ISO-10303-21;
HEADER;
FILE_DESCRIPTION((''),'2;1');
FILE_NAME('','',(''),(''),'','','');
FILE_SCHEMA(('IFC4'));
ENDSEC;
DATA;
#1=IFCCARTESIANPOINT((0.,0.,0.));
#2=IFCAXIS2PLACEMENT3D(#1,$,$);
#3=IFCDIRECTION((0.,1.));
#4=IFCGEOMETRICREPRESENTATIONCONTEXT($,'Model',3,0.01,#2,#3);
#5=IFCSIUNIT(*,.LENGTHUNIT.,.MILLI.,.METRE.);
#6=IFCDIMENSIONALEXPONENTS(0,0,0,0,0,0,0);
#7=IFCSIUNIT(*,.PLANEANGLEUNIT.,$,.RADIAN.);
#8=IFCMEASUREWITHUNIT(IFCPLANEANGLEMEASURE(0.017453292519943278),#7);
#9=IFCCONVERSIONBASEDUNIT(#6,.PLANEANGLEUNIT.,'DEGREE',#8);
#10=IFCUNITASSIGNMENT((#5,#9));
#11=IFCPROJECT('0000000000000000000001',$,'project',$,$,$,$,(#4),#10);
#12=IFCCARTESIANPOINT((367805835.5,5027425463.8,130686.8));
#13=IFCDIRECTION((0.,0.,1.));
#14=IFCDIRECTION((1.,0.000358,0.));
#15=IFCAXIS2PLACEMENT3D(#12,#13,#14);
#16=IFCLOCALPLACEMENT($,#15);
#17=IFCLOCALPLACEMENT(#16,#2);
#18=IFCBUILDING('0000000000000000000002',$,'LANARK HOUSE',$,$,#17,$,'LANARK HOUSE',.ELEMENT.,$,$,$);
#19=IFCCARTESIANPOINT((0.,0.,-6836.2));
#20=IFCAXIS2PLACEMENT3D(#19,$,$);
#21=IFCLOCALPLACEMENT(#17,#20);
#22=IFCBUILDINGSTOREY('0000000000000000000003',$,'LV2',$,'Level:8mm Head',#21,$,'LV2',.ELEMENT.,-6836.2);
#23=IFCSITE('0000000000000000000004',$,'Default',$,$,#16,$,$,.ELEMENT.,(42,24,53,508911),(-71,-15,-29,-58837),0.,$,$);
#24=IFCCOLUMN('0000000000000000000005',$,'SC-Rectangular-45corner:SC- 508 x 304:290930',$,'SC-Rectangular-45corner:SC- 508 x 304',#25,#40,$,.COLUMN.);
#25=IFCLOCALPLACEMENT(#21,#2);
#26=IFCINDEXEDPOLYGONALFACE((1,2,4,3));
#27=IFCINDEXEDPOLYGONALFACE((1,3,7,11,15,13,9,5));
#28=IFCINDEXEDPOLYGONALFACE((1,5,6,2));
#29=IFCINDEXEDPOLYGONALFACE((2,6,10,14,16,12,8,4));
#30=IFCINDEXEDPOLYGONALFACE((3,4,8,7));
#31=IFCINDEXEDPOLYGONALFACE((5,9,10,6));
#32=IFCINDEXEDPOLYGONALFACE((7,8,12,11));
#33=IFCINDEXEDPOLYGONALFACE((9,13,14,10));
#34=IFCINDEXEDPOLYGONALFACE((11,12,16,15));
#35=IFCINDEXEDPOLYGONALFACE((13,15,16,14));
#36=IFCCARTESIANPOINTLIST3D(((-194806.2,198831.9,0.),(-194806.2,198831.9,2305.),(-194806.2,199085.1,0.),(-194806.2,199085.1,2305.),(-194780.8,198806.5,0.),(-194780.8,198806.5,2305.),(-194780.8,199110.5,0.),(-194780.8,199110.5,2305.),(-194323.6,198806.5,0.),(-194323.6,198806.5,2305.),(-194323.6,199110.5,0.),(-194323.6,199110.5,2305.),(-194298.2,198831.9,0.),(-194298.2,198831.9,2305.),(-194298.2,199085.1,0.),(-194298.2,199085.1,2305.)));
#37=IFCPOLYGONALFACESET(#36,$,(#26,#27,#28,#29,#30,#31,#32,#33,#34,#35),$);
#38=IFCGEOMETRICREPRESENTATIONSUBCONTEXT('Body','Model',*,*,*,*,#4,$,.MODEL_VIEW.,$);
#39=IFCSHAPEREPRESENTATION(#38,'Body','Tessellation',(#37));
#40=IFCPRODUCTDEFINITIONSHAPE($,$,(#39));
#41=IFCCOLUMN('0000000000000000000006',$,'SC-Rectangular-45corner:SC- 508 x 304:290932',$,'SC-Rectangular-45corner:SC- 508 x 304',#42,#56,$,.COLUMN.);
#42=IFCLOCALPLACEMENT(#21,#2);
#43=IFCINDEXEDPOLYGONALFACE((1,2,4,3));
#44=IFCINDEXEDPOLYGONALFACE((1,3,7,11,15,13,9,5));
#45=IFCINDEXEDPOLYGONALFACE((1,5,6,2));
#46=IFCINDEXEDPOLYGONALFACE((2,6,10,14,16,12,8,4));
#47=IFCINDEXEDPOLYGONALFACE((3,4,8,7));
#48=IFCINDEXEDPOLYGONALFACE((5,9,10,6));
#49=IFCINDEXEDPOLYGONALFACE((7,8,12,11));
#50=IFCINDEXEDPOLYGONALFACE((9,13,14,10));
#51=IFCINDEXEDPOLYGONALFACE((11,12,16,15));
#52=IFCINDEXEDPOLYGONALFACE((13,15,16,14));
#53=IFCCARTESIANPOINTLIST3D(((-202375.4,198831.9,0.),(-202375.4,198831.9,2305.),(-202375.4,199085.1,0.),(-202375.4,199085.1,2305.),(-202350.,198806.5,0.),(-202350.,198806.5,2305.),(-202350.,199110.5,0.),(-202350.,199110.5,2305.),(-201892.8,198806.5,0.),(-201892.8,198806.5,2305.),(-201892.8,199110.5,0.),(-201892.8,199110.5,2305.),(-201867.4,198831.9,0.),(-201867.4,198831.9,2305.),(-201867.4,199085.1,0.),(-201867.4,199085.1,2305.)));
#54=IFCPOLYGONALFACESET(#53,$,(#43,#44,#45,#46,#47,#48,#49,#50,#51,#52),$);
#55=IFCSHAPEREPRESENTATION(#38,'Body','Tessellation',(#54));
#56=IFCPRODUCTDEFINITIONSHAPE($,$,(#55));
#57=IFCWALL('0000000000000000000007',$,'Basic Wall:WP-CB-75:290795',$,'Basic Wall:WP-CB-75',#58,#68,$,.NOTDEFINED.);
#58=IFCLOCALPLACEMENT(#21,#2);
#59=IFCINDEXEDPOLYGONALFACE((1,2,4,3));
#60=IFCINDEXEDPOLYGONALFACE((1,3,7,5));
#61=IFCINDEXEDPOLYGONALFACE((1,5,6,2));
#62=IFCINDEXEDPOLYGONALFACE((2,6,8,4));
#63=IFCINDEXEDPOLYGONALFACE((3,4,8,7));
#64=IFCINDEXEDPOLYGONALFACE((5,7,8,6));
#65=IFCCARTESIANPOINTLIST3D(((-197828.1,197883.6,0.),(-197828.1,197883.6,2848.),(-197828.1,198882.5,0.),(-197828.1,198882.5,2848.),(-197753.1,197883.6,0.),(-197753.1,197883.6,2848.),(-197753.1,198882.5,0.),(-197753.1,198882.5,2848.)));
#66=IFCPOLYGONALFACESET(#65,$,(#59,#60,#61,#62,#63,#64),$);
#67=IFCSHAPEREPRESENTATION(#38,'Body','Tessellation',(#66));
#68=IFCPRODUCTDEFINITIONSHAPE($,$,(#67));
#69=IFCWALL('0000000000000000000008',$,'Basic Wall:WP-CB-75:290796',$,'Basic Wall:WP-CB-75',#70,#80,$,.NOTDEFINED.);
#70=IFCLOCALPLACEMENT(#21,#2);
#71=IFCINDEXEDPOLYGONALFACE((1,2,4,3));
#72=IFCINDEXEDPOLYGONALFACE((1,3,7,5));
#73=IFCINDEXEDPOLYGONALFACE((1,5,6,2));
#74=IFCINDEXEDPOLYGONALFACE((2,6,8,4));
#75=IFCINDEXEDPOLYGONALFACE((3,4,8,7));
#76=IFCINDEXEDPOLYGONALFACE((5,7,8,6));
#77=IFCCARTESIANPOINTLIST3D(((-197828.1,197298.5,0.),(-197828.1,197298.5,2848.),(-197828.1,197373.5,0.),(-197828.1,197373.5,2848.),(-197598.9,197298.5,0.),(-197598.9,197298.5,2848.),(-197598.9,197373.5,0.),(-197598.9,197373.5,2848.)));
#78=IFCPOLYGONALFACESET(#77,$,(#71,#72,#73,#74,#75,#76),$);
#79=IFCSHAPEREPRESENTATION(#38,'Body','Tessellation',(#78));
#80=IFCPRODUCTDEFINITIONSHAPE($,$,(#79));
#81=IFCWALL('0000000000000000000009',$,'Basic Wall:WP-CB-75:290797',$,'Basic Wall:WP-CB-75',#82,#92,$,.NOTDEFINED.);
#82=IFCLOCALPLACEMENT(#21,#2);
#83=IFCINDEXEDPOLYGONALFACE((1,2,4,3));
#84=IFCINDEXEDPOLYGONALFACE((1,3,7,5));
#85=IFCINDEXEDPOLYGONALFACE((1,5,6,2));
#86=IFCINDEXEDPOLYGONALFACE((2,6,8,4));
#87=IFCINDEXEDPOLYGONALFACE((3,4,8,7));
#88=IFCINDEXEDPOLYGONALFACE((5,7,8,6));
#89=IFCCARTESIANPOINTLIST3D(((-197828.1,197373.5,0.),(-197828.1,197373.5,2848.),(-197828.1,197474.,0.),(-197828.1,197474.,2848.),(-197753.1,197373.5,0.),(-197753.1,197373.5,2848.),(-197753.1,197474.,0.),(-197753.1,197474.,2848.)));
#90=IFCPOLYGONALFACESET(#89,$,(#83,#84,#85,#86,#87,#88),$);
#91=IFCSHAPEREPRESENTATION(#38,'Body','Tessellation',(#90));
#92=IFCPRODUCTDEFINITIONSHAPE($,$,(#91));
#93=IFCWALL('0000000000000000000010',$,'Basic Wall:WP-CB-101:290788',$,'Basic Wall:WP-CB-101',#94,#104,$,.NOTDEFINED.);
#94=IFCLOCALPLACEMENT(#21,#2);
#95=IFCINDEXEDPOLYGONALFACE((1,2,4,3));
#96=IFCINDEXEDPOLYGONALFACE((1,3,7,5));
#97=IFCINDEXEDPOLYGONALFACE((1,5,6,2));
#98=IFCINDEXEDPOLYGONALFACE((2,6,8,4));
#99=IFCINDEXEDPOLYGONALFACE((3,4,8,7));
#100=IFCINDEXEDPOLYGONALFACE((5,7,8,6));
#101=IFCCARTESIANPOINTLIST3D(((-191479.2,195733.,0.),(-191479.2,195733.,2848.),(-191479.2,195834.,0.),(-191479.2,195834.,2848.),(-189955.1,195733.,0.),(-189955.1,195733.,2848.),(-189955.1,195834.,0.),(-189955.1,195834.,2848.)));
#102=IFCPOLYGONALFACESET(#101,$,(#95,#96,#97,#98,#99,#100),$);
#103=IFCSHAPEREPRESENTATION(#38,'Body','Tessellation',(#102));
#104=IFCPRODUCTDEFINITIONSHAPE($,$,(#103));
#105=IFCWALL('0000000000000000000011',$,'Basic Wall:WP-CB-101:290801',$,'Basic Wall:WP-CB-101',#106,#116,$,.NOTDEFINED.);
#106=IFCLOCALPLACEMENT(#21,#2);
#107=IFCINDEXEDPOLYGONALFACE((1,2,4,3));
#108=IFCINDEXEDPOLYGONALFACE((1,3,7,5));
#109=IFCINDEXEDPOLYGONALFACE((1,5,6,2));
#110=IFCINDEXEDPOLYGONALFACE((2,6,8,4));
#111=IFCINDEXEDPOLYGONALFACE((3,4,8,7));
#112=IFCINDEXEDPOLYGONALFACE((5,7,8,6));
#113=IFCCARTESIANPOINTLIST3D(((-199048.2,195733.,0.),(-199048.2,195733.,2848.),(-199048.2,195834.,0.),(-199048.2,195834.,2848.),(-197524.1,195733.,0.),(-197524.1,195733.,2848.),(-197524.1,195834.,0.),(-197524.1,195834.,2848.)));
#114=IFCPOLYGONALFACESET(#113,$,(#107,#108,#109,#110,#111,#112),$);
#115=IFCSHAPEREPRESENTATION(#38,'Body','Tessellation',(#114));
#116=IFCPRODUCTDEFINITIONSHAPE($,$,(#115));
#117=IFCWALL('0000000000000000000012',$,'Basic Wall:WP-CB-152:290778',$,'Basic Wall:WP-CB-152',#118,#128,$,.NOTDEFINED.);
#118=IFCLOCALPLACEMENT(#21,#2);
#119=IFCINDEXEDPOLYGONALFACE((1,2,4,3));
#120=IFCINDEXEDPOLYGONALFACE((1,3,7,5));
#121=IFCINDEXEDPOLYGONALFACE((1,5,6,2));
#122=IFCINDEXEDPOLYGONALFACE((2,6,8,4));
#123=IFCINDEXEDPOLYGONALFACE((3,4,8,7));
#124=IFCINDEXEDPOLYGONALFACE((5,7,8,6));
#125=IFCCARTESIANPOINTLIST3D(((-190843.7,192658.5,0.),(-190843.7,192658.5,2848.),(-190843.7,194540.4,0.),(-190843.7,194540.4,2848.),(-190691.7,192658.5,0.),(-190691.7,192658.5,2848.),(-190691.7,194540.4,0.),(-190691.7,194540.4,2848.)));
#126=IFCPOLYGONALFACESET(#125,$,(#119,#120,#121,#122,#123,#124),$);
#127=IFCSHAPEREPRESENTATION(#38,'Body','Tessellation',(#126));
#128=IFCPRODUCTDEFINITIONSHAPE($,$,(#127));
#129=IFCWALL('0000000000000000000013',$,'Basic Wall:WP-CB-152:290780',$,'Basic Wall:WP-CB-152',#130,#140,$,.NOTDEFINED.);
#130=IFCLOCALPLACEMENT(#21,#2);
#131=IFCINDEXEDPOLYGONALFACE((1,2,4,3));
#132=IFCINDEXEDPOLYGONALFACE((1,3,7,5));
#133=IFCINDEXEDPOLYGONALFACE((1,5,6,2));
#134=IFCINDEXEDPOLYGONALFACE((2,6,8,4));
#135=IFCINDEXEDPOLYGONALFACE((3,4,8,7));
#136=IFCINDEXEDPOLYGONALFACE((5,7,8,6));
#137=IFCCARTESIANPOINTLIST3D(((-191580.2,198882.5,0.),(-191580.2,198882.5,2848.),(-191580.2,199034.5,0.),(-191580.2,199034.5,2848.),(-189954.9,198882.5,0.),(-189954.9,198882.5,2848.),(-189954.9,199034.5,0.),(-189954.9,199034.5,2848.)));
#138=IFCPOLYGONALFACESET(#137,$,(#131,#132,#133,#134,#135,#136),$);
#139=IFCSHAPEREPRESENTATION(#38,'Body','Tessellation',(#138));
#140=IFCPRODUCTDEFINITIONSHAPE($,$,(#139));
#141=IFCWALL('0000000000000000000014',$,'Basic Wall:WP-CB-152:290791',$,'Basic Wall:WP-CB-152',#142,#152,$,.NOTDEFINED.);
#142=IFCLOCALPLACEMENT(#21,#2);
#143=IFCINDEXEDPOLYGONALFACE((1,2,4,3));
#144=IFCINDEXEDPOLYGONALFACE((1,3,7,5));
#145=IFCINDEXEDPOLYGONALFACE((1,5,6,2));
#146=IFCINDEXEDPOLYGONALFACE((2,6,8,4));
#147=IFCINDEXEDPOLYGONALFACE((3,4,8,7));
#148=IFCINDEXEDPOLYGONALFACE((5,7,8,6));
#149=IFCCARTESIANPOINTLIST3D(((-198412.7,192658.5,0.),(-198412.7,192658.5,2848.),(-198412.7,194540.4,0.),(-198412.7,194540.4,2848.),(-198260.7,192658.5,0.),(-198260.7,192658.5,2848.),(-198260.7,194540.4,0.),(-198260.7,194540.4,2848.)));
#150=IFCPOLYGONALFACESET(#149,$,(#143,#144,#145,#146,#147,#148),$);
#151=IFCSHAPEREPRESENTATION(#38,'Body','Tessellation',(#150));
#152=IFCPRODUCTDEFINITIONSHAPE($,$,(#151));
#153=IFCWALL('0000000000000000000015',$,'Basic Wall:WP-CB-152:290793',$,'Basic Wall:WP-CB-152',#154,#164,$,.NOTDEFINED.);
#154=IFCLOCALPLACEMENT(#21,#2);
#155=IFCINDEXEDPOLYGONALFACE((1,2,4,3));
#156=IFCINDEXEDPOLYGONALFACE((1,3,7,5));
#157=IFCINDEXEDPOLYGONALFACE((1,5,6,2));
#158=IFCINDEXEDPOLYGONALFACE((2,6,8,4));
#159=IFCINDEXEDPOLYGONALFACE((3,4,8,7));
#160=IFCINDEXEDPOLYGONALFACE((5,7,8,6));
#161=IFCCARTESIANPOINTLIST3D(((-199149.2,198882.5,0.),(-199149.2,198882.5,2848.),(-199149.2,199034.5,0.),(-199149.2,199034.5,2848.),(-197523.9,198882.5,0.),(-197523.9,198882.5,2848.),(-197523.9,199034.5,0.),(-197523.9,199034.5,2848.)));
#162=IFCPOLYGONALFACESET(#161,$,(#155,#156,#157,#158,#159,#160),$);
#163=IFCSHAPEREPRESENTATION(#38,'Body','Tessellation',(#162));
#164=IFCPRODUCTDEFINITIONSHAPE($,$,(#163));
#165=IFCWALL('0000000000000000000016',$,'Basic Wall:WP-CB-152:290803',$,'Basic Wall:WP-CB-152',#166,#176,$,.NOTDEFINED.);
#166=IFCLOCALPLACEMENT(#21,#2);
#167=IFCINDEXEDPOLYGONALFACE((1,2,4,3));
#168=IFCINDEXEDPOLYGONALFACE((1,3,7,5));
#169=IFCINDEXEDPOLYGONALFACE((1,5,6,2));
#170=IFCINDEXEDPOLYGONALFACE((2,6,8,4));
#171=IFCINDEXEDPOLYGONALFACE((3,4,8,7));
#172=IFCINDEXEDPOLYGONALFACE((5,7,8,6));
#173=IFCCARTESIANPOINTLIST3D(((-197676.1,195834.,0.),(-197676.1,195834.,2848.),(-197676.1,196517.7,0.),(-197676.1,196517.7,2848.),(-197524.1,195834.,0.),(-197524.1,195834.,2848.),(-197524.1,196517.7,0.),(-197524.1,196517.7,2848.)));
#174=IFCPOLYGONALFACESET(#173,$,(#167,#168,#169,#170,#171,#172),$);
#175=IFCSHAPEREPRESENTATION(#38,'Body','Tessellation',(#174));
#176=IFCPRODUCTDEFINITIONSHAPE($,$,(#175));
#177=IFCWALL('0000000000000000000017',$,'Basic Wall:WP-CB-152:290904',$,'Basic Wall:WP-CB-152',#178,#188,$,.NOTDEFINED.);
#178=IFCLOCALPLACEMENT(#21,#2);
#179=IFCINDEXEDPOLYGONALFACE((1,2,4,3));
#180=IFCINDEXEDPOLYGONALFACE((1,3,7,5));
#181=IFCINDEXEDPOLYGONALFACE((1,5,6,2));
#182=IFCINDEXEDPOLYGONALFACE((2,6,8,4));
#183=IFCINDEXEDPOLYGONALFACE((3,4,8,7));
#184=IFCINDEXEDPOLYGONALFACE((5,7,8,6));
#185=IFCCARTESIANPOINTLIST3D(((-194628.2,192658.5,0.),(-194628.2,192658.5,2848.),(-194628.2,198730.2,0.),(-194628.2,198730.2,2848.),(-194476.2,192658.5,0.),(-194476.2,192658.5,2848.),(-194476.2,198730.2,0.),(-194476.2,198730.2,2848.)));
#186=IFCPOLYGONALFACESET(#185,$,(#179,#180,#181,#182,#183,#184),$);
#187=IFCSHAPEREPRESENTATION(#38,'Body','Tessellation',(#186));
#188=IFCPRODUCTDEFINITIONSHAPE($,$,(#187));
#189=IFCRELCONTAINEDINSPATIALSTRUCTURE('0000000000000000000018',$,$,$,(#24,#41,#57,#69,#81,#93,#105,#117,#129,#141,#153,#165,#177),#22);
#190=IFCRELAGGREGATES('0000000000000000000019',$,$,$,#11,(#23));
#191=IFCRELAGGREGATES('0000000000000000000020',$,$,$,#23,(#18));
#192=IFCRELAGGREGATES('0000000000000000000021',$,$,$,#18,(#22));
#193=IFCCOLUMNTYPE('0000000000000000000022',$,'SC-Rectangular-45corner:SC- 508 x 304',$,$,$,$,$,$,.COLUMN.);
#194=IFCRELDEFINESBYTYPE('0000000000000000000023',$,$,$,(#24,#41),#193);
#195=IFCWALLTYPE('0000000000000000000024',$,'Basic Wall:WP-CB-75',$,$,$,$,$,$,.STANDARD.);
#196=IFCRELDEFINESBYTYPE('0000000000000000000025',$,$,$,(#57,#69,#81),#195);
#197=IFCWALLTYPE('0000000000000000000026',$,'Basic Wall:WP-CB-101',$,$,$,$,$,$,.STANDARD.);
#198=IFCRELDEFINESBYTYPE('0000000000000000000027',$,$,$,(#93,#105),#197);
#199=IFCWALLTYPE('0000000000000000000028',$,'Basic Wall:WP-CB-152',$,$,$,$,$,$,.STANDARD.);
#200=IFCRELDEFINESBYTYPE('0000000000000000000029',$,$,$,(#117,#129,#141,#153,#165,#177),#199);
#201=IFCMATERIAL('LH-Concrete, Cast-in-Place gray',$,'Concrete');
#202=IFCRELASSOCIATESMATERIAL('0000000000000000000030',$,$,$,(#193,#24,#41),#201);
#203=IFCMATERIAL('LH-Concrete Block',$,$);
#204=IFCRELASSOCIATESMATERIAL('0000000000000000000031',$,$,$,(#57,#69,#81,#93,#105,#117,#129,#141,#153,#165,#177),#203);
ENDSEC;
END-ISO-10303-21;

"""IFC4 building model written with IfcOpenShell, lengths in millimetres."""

from ifc_helpers import new_model, entity, si_unit, converted_unit, direction, frame, origin, place, context, subcontext, project, spatial, indexed_curve, outline, extrude, source, transform, mapped, material, type_object, type_shapes, element, save


model = new_model("IFC4")

# Units and contexts
model_context = context("Model", 3, precision=0.01, world=origin(), true_north=direction((0.0, 1.0)))
body_context = subcontext(model_context, "Body", "Model", "MODEL_VIEW")
ifc_project = project(units=[si_unit("LENGTHUNIT", "METRE", prefix="MILLI"), converted_unit("PLANEANGLEUNIT", "DEGREE", entity("IfcPlaneAngleMeasure", 0.017453292519943278), si_unit("PLANEANGLEUNIT", "RADIAN"), dimensions=[0, 0, 0, 0, 0, 0, 0])], contexts=[model_context])

# Site, building, storey
site_placement = place(None, frame((367805835.5, 5027425463.8, 130686.8), z_axis=(0.0, 0.0, 1.0), x_axis=(1.0, 0.000358, 0.0)))
site = spatial("IfcSite", under=ifc_project, at=site_placement, Name="Default", CompositionType="ELEMENT", RefLatitude=(42, 24, 53, 508911), RefLongitude=(-71, -15, -29, -58837), RefElevation=0.0)
building_placement = place(site_placement, origin())
building = spatial("IfcBuilding", under=site, at=building_placement, Name="LANARK HOUSE", LongName="LANARK HOUSE", CompositionType="ELEMENT")
storey_placement = place(building_placement, frame((0.0, 0.0, -6836.2)))
storey = spatial("IfcBuildingStorey", under=building, at=storey_placement, Name="LV2", ObjectType="Level:8mm Head", LongName="LV2", CompositionType="ELEMENT", Elevation=-6836.2)

# Columns
ifc_material_1 = material(Name="LH-Concrete, Cast-in-Place gray", Category="Concrete")
column_type = type_object("IfcColumnType", Name="SC-Rectangular-45corner:SC- 508 x 304", PredefinedType="COLUMN", material=ifc_material_1)
shared_shape = source(origin(), body_context, "Body", "SweptSolid", [
    extrude(outline(indexed_curve([(-228.6, -152.0), (228.6, -152.0), (254.0, -126.6), (254.0, 126.6), (228.6, 152.0), (-228.6, 152.0), (-254.0, 126.6), (-254.0, -126.6), (-228.6, -152.0)], self_intersect=False)), frame((0.0, 0.0, -6836.2), z_axis=(0.0, 0.0, 1.0), x_axis=(-1.0, 0.0, 0.0)), (0.0, 0.0, 1.0), 2305.0),
])
type_shapes(column_type, [shared_shape])
for number, where, name in (
    (1, (-194552.2, 198958.5, 6836.2), "SC-Rectangular-45corner:SC- 508 x 304:290930"),
    (2, (-202121.4, 198958.5, 6836.2), "SC-Rectangular-45corner:SC- 508 x 304:290932"),
):
    element("IfcColumn", number, at=place(storey_placement, frame(where)), inside=storey, type_object=column_type, material=ifc_material_1, Name=name, ObjectType="SC-Rectangular-45corner:SC- 508 x 304", PredefinedType="COLUMN", context=body_context, shape_type="MappedRepresentation", body=[
        mapped(shared_shape, transform((0.0, 0.0, 0.0), scale=1.0)),
    ])

# Walls
ifc_material_2 = material(Name="LH-Concrete Block")
wall_type_1 = type_object("IfcWallType", Name="Basic Wall:WP-CB-75", PredefinedType="STANDARD")
wall_1_placement = place(storey_placement, frame((-197790.6, 198882.5, 0.0), z_axis=(0.0, 0.0, 1.0), x_axis=(0.0, -1.0, 0.0)))
element("IfcWall", 3, at=wall_1_placement, inside=storey, type_object=wall_type_1, material=ifc_material_2, Name="Basic Wall:WP-CB-75:290795", ObjectType="Basic Wall:WP-CB-75", PredefinedType="NOTDEFINED", context=body_context, shape_type="SweptSolid", body=[
    extrude(outline(indexed_curve([(998.9, 37.5), (0.0, 37.5), (0.0, -37.5), (998.9, -37.5), (998.9, 37.5)], self_intersect=False)), origin(), (0.0, 0.0, 1.0), 2848.0),
])
wall_2_placement = place(storey_placement, frame((-197598.9, 197336.0, 0.0), z_axis=(0.0, 0.0, 1.0), x_axis=(-1.0, 0.0, 0.0)))
element("IfcWall", 4, at=wall_2_placement, inside=storey, type_object=wall_type_1, material=ifc_material_2, Name="Basic Wall:WP-CB-75:290796", ObjectType="Basic Wall:WP-CB-75", PredefinedType="NOTDEFINED", context=body_context, shape_type="SweptSolid", body=[
    extrude(outline(indexed_curve([(229.2, 37.5), (0.0, 37.5), (0.0, -37.5), (229.2, -37.5), (229.2, 37.5)], self_intersect=False)), origin(), (0.0, 0.0, 1.0), 2848.0),
])
wall_3_placement = place(storey_placement, frame((-197790.6, 197373.5, 0.0), z_axis=(0.0, 0.0, 1.0), x_axis=(0.0, 1.0, 0.0)))
element("IfcWall", 5, at=wall_3_placement, inside=storey, type_object=wall_type_1, material=ifc_material_2, Name="Basic Wall:WP-CB-75:290797", ObjectType="Basic Wall:WP-CB-75", PredefinedType="NOTDEFINED", context=body_context, shape_type="SweptSolid", body=[
    extrude(outline(indexed_curve([(100.5, 37.5), (0.0, 37.5), (0.0, -37.5), (100.5, -37.5), (100.5, 37.5)], self_intersect=False)), origin(), (0.0, 0.0, 1.0), 2848.0),
])
wall_type_2 = type_object("IfcWallType", Name="Basic Wall:WP-CB-101", PredefinedType="STANDARD")
for number, where, name in (
    (6, (-191479.2, 195783.5, 0.0), "Basic Wall:WP-CB-101:290788"),
    (7, (-199048.2, 195783.5, 0.0), "Basic Wall:WP-CB-101:290801"),
):
    element("IfcWall", number, at=place(storey_placement, frame(where)), inside=storey, type_object=wall_type_2, material=ifc_material_2, Name=name, ObjectType="Basic Wall:WP-CB-101", PredefinedType="NOTDEFINED", context=body_context, shape_type="SweptSolid", body=[
        extrude(outline(indexed_curve([(1524.1, 50.5), (0.0, 50.5), (0.0, -50.5), (1524.1, -50.5), (1524.1, 50.5)], self_intersect=False)), origin(), (0.0, 0.0, 1.0), 2848.0),
    ])
wall_type_3 = type_object("IfcWallType", Name="Basic Wall:WP-CB-152", PredefinedType="STANDARD")
wall_4_placement = place(storey_placement, frame((-190767.7, 194540.4, 0.0), z_axis=(0.0, 0.0, 1.0), x_axis=(0.0, -1.0, 0.0)))
element("IfcWall", 8, at=wall_4_placement, inside=storey, type_object=wall_type_3, material=ifc_material_2, Name="Basic Wall:WP-CB-152:290778", ObjectType="Basic Wall:WP-CB-152", PredefinedType="NOTDEFINED", context=body_context, shape_type="SweptSolid", body=[
    extrude(outline(indexed_curve([(1881.9, 76.0), (0.0, 76.0), (0.0, -76.0), (1881.9, -76.0), (1881.9, 76.0)], self_intersect=False)), origin(), (0.0, 0.0, 1.0), 2848.0),
])
wall_5_placement = place(storey_placement, frame((-191580.2, 198958.5, 0.0)))
element("IfcWall", 9, at=wall_5_placement, inside=storey, type_object=wall_type_3, material=ifc_material_2, Name="Basic Wall:WP-CB-152:290780", ObjectType="Basic Wall:WP-CB-152", PredefinedType="NOTDEFINED", context=body_context, shape_type="SweptSolid", body=[
    extrude(outline(indexed_curve([(1625.3, 76.0), (0.0, 76.0), (0.0, -76.0), (1625.3, -76.0), (1625.3, 76.0)], self_intersect=False)), origin(), (0.0, 0.0, 1.0), 2848.0),
])
wall_6_placement = place(storey_placement, frame((-198336.7, 194540.4, 0.0), z_axis=(0.0, 0.0, 1.0), x_axis=(0.0, -1.0, 0.0)))
element("IfcWall", 10, at=wall_6_placement, inside=storey, type_object=wall_type_3, material=ifc_material_2, Name="Basic Wall:WP-CB-152:290791", ObjectType="Basic Wall:WP-CB-152", PredefinedType="NOTDEFINED", context=body_context, shape_type="SweptSolid", body=[
    extrude(outline(indexed_curve([(1881.9, 76.0), (0.0, 76.0), (0.0, -76.0), (1881.9, -76.0), (1881.9, 76.0)], self_intersect=False)), origin(), (0.0, 0.0, 1.0), 2848.0),
])
wall_7_placement = place(storey_placement, frame((-199149.2, 198958.5, 0.0)))
element("IfcWall", 11, at=wall_7_placement, inside=storey, type_object=wall_type_3, material=ifc_material_2, Name="Basic Wall:WP-CB-152:290793", ObjectType="Basic Wall:WP-CB-152", PredefinedType="NOTDEFINED", context=body_context, shape_type="SweptSolid", body=[
    extrude(outline(indexed_curve([(1625.3, 76.0), (0.0, 76.0), (0.0, -76.0), (1625.3, -76.0), (1625.3, 76.0)], self_intersect=False)), origin(), (0.0, 0.0, 1.0), 2848.0),
])
wall_8_placement = place(storey_placement, frame((-197600.1, 196517.7, 0.0), z_axis=(0.0, 0.0, 1.0), x_axis=(0.0, -1.0, 0.0)))
element("IfcWall", 12, at=wall_8_placement, inside=storey, type_object=wall_type_3, material=ifc_material_2, Name="Basic Wall:WP-CB-152:290803", ObjectType="Basic Wall:WP-CB-152", PredefinedType="NOTDEFINED", context=body_context, shape_type="SweptSolid", body=[
    extrude(outline(indexed_curve([(683.7, 76.0), (0.0, 76.0), (0.0, -76.0), (683.7, -76.0), (683.7, 76.0)], self_intersect=False)), origin(), (0.0, 0.0, 1.0), 2848.0),
])
wall_9_placement = place(storey_placement, frame((-194552.2, 198730.2, 0.0), z_axis=(0.0, 0.0, 1.0), x_axis=(0.0, -1.0, 0.0)))
element("IfcWall", 13, at=wall_9_placement, inside=storey, type_object=wall_type_3, material=ifc_material_2, Name="Basic Wall:WP-CB-152:290904", ObjectType="Basic Wall:WP-CB-152", PredefinedType="NOTDEFINED", context=body_context, shape_type="SweptSolid", body=[
    extrude(outline(indexed_curve([(6071.8, 76.0), (0.0, 76.0), (0.0, -76.0), (6071.8, -76.0), (6071.8, 76.0)], self_intersect=False)), origin(), (0.0, 0.0, 1.0), 2848.0),
])

save(model, "model.ifc")
